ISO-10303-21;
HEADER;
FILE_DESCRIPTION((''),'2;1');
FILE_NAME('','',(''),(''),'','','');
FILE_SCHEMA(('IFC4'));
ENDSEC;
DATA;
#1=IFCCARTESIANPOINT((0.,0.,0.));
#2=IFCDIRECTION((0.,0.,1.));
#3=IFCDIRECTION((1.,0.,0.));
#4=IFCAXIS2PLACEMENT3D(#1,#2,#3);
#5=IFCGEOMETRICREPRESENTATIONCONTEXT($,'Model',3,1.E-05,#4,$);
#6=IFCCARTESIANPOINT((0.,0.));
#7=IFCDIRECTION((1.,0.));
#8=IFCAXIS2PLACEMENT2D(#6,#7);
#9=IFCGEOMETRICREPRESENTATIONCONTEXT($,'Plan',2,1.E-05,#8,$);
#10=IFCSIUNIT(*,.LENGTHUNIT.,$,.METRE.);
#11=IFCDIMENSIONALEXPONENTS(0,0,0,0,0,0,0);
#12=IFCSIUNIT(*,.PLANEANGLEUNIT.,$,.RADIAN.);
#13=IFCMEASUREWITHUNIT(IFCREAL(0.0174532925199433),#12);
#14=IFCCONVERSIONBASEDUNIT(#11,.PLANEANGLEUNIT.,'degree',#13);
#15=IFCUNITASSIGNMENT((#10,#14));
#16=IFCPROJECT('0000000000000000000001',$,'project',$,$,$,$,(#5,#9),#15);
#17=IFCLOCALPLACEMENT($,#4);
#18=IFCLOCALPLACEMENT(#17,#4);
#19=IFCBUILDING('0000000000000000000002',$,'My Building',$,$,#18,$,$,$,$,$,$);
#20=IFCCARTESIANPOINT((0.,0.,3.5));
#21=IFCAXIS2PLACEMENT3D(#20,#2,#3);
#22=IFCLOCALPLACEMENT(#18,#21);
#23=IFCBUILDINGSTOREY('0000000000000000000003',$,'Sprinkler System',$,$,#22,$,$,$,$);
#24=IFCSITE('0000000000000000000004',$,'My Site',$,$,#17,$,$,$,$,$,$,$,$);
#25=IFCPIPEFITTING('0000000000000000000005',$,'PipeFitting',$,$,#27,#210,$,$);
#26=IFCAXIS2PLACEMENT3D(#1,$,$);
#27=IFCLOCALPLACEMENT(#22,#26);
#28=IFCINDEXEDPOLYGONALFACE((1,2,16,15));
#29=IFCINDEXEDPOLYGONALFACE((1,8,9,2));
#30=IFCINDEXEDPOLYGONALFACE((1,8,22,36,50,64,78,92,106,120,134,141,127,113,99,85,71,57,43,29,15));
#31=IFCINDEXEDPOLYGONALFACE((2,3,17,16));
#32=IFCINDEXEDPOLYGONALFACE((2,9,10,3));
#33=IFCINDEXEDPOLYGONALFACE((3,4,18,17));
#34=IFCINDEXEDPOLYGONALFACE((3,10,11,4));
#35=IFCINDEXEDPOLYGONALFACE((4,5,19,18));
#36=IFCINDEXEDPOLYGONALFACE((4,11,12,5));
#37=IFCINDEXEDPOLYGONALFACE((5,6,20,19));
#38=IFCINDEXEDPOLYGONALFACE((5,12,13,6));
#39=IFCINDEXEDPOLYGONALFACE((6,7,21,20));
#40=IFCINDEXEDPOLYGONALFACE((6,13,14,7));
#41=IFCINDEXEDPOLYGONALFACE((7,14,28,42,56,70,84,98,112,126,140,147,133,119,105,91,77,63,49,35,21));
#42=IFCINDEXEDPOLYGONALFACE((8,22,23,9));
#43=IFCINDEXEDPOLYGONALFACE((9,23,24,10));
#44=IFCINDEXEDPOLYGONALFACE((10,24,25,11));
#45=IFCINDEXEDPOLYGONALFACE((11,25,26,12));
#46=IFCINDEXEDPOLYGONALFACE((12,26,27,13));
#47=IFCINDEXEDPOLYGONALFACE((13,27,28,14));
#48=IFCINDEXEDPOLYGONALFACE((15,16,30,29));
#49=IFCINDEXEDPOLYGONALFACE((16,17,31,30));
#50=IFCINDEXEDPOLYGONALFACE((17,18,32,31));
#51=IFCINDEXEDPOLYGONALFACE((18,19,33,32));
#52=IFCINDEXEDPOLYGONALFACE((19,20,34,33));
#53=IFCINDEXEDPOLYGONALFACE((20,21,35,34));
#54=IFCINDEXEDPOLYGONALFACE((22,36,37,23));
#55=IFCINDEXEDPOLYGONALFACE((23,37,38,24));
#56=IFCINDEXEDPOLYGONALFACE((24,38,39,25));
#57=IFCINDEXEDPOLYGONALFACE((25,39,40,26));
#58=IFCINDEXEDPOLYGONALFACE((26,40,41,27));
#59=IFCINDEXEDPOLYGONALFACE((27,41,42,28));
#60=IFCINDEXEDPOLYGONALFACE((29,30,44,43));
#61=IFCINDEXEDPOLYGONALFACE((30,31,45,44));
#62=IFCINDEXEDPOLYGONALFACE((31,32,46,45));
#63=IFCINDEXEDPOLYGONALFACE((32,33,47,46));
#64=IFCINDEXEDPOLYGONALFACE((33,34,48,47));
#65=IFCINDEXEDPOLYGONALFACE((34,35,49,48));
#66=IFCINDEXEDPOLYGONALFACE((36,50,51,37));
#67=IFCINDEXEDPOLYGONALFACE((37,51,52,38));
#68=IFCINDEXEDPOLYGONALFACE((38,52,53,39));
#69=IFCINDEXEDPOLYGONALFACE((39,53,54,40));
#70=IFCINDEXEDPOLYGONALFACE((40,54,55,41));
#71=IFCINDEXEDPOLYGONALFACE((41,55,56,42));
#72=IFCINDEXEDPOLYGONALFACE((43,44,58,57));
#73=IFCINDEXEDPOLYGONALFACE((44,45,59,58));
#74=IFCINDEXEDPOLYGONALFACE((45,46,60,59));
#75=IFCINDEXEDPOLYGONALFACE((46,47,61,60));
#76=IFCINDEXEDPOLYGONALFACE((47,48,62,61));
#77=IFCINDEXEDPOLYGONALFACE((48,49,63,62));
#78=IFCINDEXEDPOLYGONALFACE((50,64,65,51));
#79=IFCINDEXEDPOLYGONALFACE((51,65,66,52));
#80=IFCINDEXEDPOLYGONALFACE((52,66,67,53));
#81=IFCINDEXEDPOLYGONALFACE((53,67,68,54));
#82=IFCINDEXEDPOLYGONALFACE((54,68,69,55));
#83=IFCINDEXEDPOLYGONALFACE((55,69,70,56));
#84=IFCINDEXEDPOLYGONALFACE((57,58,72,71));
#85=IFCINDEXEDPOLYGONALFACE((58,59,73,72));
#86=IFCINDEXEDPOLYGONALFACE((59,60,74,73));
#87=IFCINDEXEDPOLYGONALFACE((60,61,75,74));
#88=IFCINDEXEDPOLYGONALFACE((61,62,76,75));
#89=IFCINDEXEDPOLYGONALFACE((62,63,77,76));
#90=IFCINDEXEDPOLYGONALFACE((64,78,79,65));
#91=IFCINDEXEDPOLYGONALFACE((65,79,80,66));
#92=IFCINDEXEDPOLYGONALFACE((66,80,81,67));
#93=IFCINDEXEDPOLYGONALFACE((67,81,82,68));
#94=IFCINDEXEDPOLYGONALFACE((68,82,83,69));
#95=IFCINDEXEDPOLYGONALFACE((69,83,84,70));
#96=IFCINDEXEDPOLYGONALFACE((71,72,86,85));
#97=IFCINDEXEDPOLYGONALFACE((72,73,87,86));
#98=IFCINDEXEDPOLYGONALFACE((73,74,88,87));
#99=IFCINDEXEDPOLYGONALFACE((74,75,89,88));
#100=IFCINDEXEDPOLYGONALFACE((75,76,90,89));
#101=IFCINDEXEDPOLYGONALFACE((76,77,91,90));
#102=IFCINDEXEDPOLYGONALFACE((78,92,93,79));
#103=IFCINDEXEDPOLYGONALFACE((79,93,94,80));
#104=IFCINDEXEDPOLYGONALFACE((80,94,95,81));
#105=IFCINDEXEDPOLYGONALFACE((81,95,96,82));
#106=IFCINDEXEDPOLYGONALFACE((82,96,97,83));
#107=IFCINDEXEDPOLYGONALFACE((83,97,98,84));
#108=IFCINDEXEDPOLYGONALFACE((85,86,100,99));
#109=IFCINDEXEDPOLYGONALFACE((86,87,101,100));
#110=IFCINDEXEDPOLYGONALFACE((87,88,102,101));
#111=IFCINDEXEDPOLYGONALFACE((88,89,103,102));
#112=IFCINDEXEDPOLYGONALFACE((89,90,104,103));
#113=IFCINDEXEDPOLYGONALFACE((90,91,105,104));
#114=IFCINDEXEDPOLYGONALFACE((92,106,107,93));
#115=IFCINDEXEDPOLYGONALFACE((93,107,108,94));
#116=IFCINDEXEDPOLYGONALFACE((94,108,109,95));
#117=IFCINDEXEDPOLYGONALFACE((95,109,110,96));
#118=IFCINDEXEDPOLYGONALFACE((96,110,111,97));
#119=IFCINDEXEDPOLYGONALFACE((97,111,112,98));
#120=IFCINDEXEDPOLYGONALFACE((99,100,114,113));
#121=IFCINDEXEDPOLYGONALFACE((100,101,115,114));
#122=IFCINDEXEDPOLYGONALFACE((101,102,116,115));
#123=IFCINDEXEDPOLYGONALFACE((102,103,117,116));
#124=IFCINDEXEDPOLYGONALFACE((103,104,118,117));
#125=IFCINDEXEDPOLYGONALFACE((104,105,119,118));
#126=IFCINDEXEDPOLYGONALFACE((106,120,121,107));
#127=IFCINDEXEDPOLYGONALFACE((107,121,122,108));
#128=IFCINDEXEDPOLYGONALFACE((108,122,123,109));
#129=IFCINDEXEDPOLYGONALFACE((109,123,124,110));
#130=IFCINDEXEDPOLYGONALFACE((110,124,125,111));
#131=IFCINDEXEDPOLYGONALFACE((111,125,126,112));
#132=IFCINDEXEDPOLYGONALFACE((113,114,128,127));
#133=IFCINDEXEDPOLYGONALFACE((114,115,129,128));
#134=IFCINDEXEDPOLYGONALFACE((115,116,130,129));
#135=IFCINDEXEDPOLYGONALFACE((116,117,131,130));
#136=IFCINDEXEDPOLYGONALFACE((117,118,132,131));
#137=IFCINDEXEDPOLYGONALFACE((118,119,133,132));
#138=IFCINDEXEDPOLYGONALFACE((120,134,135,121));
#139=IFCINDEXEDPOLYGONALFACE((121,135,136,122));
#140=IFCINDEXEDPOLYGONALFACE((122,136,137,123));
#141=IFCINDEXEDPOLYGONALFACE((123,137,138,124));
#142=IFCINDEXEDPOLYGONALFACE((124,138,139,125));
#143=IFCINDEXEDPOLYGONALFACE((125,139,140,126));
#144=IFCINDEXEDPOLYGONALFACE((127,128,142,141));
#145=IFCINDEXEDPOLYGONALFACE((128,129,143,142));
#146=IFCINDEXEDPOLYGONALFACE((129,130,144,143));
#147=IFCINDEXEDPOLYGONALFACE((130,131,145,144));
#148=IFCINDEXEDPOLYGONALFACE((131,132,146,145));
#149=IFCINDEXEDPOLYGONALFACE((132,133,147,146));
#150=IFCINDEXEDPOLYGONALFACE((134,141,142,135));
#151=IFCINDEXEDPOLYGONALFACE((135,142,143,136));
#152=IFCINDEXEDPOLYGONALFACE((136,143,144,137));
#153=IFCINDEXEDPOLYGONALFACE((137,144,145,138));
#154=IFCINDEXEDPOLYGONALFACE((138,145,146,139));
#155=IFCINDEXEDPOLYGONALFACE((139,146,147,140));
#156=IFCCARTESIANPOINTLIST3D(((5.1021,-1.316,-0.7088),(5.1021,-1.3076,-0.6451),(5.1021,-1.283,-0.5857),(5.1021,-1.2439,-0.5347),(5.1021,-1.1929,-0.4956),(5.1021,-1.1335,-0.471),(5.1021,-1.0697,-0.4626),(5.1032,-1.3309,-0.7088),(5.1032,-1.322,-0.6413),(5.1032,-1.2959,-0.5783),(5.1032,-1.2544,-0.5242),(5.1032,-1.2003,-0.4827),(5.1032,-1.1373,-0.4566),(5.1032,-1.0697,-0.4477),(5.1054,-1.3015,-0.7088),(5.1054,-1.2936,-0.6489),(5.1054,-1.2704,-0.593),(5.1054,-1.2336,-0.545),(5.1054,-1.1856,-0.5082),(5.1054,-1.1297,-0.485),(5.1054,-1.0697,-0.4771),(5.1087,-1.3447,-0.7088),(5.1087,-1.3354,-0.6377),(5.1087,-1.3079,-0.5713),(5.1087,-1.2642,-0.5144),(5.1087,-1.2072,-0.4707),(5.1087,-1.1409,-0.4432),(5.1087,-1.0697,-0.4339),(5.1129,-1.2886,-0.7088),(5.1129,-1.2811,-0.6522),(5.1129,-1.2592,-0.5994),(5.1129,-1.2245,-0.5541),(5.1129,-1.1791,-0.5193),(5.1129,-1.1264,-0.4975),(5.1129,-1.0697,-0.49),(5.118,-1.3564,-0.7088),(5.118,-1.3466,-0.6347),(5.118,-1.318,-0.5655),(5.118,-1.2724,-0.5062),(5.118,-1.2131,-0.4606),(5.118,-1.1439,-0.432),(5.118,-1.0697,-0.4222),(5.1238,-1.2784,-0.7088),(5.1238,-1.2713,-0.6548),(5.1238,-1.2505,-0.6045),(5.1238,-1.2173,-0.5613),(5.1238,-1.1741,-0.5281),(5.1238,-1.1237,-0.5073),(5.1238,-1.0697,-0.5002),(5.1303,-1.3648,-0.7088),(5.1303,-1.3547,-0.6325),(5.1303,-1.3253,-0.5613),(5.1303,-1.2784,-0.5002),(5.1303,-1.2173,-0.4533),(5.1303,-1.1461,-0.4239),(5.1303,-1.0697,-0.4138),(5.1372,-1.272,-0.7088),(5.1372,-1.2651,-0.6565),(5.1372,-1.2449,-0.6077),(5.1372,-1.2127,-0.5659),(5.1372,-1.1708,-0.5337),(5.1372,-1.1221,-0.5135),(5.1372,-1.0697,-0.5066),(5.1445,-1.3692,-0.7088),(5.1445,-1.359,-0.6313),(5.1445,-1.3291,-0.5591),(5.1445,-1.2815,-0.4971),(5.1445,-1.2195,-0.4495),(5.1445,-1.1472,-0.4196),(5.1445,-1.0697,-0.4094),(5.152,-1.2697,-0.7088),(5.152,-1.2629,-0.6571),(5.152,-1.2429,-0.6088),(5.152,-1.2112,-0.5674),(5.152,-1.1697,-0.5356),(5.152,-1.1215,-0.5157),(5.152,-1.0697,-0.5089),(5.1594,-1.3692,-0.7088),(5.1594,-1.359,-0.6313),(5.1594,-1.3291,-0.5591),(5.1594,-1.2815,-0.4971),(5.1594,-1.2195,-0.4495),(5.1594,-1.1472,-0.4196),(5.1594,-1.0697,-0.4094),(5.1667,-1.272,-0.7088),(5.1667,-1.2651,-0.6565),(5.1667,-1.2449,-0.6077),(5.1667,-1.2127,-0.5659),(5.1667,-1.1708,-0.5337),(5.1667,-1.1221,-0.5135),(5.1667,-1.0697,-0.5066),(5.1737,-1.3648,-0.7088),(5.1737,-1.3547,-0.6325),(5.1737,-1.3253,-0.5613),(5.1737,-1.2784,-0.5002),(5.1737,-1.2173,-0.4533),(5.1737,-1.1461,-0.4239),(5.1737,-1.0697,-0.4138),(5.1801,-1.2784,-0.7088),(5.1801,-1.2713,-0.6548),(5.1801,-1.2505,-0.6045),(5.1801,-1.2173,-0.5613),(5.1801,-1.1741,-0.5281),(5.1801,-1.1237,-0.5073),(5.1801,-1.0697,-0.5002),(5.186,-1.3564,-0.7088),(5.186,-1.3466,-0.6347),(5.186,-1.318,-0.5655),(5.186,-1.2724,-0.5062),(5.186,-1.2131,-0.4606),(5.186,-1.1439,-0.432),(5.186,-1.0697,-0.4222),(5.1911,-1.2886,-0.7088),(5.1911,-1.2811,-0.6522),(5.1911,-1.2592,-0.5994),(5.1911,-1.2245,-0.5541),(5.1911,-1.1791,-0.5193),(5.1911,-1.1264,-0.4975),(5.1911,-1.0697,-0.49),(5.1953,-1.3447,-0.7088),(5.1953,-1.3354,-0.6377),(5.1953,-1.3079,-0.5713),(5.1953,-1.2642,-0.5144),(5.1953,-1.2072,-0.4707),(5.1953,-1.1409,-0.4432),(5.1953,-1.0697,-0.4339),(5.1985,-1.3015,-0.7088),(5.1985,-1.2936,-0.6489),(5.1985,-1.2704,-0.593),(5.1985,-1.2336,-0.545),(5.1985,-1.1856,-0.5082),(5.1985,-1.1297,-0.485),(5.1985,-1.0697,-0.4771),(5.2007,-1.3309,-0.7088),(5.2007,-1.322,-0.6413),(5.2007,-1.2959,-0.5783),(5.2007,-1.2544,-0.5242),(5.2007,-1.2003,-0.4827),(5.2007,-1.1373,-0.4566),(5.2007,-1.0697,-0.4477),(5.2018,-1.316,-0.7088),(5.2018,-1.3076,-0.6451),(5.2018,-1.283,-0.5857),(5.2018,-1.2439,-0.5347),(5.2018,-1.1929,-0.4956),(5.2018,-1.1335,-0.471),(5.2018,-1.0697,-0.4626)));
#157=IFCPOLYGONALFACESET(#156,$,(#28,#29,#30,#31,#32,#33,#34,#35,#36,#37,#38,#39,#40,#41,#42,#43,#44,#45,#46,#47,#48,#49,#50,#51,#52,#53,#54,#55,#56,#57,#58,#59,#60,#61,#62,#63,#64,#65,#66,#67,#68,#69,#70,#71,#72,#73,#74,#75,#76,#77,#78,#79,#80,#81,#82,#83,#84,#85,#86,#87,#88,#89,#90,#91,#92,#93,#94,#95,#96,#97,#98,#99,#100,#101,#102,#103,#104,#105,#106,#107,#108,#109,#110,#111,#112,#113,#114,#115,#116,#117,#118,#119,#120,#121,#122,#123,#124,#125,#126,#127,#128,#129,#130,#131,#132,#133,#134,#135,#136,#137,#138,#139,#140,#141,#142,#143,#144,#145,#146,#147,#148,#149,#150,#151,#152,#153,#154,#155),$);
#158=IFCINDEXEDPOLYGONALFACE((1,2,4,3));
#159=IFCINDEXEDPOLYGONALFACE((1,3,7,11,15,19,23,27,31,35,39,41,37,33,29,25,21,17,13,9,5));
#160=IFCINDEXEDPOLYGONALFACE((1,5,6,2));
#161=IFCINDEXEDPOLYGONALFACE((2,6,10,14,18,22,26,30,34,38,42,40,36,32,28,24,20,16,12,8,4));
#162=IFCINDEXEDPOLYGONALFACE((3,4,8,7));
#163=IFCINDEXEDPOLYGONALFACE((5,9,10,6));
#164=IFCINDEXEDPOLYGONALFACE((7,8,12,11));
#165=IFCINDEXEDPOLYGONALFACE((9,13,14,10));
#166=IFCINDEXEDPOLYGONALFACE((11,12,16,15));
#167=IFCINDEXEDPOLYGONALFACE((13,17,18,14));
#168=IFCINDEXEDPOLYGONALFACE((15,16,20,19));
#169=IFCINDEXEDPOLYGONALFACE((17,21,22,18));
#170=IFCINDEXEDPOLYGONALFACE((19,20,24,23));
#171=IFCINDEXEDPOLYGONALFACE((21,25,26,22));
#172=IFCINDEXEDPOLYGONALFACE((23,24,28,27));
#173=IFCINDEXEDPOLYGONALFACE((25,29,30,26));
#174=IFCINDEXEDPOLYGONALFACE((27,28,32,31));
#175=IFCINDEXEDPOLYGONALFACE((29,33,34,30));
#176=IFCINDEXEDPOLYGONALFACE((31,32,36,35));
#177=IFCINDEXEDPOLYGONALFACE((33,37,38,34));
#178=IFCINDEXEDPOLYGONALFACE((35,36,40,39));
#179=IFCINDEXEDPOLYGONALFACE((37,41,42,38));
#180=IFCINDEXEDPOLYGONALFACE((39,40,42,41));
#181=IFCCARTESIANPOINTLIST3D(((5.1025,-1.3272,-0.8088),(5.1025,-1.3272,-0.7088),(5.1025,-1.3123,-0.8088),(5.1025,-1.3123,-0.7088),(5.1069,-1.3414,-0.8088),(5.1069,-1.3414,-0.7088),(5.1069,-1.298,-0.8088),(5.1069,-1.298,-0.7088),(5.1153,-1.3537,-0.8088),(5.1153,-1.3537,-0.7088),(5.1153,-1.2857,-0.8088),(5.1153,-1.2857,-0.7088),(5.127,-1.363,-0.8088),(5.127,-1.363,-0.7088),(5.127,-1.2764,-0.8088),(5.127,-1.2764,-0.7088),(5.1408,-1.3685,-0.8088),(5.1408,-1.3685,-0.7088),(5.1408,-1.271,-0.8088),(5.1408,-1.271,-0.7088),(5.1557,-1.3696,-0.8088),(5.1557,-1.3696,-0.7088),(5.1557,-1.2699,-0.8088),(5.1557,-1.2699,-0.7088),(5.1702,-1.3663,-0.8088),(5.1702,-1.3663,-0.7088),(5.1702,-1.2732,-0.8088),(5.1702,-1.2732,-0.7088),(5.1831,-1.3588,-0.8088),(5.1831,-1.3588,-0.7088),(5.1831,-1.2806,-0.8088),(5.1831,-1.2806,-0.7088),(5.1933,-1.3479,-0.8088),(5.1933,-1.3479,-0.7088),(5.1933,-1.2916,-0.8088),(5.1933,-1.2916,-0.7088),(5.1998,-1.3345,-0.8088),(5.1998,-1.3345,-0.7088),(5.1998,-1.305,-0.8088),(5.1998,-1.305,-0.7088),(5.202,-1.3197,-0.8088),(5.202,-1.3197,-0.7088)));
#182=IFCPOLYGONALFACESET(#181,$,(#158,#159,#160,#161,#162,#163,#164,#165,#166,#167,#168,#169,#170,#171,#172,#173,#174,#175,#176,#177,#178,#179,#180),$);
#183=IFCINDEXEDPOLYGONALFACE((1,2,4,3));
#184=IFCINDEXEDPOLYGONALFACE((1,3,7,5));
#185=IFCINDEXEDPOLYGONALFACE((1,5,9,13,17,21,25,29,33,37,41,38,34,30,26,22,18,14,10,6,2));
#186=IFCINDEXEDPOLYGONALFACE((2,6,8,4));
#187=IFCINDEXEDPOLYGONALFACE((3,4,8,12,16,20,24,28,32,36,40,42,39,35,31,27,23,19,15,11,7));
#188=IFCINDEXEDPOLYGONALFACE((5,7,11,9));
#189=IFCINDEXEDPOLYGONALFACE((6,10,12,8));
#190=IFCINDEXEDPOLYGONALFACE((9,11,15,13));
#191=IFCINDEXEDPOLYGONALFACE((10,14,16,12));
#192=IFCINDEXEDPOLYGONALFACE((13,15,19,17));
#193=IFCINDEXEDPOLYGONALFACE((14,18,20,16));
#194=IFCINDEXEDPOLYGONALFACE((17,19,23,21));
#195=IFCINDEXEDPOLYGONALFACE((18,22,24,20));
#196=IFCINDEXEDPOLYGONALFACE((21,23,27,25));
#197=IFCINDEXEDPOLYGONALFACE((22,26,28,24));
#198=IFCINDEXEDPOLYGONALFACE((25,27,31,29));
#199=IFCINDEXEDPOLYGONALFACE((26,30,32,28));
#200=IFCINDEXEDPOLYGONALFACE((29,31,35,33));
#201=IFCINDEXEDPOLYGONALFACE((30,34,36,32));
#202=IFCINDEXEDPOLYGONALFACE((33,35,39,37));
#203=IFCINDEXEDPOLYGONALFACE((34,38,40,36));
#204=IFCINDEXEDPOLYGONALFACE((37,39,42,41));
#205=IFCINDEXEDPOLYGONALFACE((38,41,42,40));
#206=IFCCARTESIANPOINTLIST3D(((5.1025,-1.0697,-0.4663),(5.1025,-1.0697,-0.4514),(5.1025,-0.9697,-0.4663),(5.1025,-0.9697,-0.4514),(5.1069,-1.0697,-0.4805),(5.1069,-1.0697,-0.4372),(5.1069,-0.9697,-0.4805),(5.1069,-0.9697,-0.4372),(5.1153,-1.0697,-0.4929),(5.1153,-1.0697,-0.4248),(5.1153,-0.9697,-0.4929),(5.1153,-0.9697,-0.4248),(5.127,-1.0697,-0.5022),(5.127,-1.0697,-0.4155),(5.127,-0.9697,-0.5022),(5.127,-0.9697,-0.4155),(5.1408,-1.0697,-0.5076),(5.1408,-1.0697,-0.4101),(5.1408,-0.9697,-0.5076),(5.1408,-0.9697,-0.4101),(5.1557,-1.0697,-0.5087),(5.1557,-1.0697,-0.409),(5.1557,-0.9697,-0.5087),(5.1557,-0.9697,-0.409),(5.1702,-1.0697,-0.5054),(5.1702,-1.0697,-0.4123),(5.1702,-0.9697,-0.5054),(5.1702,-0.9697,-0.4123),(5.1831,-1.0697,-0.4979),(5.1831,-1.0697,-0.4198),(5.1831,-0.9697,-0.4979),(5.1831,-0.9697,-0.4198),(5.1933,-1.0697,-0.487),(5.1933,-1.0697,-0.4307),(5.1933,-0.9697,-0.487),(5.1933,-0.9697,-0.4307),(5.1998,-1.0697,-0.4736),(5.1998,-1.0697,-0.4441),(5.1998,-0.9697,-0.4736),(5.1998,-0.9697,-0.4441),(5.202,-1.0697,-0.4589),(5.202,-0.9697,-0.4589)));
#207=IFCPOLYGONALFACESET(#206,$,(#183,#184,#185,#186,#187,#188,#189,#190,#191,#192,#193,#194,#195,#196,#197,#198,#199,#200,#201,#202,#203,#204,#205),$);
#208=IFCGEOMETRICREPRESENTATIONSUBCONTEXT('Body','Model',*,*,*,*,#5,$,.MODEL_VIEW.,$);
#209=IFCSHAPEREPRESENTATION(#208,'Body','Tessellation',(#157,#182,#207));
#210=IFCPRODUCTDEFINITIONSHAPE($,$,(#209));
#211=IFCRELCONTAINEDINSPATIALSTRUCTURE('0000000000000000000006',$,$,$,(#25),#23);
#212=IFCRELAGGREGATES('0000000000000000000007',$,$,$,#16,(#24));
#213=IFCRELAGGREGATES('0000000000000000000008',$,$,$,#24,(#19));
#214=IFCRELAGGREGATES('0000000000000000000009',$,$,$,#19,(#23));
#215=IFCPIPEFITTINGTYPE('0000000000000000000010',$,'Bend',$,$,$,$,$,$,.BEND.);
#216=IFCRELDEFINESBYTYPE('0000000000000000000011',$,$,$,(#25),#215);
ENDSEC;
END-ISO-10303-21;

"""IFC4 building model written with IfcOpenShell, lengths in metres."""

from ifc_helpers import new_model, entity, si_unit, converted_unit, frame, origin_with_axes, origin_2d_with_axis, place, context, subcontext, project, spatial, circle, extrude, source, transform, mapped, type_object, type_shapes, element, save


model = new_model("IFC4")

# Units and contexts
model_context = context("Model", 3, precision=1e-05, world=origin_with_axes())
plan_context = context("Plan", 2, precision=1e-05, world=origin_2d_with_axis())
body_context = subcontext(model_context, "Body", "Model", "MODEL_VIEW")
ifc_project = project(units=[si_unit("LENGTHUNIT", "METRE"), converted_unit("PLANEANGLEUNIT", "degree", entity("IfcReal", 0.0174532925199433), si_unit("PLANEANGLEUNIT", "RADIAN"), dimensions=[0, 0, 0, 0, 0, 0, 0])], contexts=[model_context, plan_context])

# Site, building, storey
site_placement = place(None, origin_with_axes())
site = spatial("IfcSite", under=ifc_project, at=site_placement, Name="My Site")
building_placement = place(site_placement, origin_with_axes())
building = spatial("IfcBuilding", under=site, at=building_placement, Name="My Building")
storey_placement = place(building_placement, frame((0.0, 0.0, 3.5), z_axis=(0.0, 0.0, 1.0), x_axis=(1.0, 0.0, 0.0)))
storey = spatial("IfcBuildingStorey", under=building, at=storey_placement, Name="Sprinkler System")

# Pipe fitting
pipe_fitting_type_1 = type_object("IfcPipeFittingType", Name="Bend", PredefinedType="BEND")
shared_shape_1 = source(origin_with_axes(), body_context, "Body", "SolidModel", [
    entity("IfcSweptDiskSolid", entity("IfcIndexedPolyCurve", entity("IfcCartesianPointList3D", [[0.0, 0.0, -0.1], [0.0, -0.0732, -0.2768], [0.0, -0.25, -0.35]]), [entity("IfcArcIndex", [1, 2, 3])]), 0.05),
    extrude(circle(Radius=0.05), origin_with_axes(), (0.0, 0.0, -1.0), 0.1),
    extrude(circle(Radius=0.05), frame((0.0, -0.25, -0.35), z_axis=(0.0, -1.0, -0.000033), x_axis=(1.0, 0.0, 0.0)), (0.0, 0.0, 1.0), 0.1),
])
type_shapes(pipe_fitting_type_1, [shared_shape_1])
pipe_fitting_1_placement = place(storey_placement, frame((5.152, -1.3197, -0.8088), z_axis=(0.0, -0.000034, -1.0), x_axis=(1.0, -0.000001, 0.0)))
element("IfcPipeFitting", 1, at=pipe_fitting_1_placement, inside=storey, type_object=pipe_fitting_type_1, Name="PipeFitting", context=body_context, shape_type="MappedRepresentation", body=[
    mapped(shared_shape_1, transform((0.0, 0.0, 0.0), x_axis=(1.0, 0.0, 0.0), y_axis=(0.0, 1.0, 0.0), z_axis=(0.0, 0.0, 1.0), scale=1.0)),
])

save(model, "model.ifc")
